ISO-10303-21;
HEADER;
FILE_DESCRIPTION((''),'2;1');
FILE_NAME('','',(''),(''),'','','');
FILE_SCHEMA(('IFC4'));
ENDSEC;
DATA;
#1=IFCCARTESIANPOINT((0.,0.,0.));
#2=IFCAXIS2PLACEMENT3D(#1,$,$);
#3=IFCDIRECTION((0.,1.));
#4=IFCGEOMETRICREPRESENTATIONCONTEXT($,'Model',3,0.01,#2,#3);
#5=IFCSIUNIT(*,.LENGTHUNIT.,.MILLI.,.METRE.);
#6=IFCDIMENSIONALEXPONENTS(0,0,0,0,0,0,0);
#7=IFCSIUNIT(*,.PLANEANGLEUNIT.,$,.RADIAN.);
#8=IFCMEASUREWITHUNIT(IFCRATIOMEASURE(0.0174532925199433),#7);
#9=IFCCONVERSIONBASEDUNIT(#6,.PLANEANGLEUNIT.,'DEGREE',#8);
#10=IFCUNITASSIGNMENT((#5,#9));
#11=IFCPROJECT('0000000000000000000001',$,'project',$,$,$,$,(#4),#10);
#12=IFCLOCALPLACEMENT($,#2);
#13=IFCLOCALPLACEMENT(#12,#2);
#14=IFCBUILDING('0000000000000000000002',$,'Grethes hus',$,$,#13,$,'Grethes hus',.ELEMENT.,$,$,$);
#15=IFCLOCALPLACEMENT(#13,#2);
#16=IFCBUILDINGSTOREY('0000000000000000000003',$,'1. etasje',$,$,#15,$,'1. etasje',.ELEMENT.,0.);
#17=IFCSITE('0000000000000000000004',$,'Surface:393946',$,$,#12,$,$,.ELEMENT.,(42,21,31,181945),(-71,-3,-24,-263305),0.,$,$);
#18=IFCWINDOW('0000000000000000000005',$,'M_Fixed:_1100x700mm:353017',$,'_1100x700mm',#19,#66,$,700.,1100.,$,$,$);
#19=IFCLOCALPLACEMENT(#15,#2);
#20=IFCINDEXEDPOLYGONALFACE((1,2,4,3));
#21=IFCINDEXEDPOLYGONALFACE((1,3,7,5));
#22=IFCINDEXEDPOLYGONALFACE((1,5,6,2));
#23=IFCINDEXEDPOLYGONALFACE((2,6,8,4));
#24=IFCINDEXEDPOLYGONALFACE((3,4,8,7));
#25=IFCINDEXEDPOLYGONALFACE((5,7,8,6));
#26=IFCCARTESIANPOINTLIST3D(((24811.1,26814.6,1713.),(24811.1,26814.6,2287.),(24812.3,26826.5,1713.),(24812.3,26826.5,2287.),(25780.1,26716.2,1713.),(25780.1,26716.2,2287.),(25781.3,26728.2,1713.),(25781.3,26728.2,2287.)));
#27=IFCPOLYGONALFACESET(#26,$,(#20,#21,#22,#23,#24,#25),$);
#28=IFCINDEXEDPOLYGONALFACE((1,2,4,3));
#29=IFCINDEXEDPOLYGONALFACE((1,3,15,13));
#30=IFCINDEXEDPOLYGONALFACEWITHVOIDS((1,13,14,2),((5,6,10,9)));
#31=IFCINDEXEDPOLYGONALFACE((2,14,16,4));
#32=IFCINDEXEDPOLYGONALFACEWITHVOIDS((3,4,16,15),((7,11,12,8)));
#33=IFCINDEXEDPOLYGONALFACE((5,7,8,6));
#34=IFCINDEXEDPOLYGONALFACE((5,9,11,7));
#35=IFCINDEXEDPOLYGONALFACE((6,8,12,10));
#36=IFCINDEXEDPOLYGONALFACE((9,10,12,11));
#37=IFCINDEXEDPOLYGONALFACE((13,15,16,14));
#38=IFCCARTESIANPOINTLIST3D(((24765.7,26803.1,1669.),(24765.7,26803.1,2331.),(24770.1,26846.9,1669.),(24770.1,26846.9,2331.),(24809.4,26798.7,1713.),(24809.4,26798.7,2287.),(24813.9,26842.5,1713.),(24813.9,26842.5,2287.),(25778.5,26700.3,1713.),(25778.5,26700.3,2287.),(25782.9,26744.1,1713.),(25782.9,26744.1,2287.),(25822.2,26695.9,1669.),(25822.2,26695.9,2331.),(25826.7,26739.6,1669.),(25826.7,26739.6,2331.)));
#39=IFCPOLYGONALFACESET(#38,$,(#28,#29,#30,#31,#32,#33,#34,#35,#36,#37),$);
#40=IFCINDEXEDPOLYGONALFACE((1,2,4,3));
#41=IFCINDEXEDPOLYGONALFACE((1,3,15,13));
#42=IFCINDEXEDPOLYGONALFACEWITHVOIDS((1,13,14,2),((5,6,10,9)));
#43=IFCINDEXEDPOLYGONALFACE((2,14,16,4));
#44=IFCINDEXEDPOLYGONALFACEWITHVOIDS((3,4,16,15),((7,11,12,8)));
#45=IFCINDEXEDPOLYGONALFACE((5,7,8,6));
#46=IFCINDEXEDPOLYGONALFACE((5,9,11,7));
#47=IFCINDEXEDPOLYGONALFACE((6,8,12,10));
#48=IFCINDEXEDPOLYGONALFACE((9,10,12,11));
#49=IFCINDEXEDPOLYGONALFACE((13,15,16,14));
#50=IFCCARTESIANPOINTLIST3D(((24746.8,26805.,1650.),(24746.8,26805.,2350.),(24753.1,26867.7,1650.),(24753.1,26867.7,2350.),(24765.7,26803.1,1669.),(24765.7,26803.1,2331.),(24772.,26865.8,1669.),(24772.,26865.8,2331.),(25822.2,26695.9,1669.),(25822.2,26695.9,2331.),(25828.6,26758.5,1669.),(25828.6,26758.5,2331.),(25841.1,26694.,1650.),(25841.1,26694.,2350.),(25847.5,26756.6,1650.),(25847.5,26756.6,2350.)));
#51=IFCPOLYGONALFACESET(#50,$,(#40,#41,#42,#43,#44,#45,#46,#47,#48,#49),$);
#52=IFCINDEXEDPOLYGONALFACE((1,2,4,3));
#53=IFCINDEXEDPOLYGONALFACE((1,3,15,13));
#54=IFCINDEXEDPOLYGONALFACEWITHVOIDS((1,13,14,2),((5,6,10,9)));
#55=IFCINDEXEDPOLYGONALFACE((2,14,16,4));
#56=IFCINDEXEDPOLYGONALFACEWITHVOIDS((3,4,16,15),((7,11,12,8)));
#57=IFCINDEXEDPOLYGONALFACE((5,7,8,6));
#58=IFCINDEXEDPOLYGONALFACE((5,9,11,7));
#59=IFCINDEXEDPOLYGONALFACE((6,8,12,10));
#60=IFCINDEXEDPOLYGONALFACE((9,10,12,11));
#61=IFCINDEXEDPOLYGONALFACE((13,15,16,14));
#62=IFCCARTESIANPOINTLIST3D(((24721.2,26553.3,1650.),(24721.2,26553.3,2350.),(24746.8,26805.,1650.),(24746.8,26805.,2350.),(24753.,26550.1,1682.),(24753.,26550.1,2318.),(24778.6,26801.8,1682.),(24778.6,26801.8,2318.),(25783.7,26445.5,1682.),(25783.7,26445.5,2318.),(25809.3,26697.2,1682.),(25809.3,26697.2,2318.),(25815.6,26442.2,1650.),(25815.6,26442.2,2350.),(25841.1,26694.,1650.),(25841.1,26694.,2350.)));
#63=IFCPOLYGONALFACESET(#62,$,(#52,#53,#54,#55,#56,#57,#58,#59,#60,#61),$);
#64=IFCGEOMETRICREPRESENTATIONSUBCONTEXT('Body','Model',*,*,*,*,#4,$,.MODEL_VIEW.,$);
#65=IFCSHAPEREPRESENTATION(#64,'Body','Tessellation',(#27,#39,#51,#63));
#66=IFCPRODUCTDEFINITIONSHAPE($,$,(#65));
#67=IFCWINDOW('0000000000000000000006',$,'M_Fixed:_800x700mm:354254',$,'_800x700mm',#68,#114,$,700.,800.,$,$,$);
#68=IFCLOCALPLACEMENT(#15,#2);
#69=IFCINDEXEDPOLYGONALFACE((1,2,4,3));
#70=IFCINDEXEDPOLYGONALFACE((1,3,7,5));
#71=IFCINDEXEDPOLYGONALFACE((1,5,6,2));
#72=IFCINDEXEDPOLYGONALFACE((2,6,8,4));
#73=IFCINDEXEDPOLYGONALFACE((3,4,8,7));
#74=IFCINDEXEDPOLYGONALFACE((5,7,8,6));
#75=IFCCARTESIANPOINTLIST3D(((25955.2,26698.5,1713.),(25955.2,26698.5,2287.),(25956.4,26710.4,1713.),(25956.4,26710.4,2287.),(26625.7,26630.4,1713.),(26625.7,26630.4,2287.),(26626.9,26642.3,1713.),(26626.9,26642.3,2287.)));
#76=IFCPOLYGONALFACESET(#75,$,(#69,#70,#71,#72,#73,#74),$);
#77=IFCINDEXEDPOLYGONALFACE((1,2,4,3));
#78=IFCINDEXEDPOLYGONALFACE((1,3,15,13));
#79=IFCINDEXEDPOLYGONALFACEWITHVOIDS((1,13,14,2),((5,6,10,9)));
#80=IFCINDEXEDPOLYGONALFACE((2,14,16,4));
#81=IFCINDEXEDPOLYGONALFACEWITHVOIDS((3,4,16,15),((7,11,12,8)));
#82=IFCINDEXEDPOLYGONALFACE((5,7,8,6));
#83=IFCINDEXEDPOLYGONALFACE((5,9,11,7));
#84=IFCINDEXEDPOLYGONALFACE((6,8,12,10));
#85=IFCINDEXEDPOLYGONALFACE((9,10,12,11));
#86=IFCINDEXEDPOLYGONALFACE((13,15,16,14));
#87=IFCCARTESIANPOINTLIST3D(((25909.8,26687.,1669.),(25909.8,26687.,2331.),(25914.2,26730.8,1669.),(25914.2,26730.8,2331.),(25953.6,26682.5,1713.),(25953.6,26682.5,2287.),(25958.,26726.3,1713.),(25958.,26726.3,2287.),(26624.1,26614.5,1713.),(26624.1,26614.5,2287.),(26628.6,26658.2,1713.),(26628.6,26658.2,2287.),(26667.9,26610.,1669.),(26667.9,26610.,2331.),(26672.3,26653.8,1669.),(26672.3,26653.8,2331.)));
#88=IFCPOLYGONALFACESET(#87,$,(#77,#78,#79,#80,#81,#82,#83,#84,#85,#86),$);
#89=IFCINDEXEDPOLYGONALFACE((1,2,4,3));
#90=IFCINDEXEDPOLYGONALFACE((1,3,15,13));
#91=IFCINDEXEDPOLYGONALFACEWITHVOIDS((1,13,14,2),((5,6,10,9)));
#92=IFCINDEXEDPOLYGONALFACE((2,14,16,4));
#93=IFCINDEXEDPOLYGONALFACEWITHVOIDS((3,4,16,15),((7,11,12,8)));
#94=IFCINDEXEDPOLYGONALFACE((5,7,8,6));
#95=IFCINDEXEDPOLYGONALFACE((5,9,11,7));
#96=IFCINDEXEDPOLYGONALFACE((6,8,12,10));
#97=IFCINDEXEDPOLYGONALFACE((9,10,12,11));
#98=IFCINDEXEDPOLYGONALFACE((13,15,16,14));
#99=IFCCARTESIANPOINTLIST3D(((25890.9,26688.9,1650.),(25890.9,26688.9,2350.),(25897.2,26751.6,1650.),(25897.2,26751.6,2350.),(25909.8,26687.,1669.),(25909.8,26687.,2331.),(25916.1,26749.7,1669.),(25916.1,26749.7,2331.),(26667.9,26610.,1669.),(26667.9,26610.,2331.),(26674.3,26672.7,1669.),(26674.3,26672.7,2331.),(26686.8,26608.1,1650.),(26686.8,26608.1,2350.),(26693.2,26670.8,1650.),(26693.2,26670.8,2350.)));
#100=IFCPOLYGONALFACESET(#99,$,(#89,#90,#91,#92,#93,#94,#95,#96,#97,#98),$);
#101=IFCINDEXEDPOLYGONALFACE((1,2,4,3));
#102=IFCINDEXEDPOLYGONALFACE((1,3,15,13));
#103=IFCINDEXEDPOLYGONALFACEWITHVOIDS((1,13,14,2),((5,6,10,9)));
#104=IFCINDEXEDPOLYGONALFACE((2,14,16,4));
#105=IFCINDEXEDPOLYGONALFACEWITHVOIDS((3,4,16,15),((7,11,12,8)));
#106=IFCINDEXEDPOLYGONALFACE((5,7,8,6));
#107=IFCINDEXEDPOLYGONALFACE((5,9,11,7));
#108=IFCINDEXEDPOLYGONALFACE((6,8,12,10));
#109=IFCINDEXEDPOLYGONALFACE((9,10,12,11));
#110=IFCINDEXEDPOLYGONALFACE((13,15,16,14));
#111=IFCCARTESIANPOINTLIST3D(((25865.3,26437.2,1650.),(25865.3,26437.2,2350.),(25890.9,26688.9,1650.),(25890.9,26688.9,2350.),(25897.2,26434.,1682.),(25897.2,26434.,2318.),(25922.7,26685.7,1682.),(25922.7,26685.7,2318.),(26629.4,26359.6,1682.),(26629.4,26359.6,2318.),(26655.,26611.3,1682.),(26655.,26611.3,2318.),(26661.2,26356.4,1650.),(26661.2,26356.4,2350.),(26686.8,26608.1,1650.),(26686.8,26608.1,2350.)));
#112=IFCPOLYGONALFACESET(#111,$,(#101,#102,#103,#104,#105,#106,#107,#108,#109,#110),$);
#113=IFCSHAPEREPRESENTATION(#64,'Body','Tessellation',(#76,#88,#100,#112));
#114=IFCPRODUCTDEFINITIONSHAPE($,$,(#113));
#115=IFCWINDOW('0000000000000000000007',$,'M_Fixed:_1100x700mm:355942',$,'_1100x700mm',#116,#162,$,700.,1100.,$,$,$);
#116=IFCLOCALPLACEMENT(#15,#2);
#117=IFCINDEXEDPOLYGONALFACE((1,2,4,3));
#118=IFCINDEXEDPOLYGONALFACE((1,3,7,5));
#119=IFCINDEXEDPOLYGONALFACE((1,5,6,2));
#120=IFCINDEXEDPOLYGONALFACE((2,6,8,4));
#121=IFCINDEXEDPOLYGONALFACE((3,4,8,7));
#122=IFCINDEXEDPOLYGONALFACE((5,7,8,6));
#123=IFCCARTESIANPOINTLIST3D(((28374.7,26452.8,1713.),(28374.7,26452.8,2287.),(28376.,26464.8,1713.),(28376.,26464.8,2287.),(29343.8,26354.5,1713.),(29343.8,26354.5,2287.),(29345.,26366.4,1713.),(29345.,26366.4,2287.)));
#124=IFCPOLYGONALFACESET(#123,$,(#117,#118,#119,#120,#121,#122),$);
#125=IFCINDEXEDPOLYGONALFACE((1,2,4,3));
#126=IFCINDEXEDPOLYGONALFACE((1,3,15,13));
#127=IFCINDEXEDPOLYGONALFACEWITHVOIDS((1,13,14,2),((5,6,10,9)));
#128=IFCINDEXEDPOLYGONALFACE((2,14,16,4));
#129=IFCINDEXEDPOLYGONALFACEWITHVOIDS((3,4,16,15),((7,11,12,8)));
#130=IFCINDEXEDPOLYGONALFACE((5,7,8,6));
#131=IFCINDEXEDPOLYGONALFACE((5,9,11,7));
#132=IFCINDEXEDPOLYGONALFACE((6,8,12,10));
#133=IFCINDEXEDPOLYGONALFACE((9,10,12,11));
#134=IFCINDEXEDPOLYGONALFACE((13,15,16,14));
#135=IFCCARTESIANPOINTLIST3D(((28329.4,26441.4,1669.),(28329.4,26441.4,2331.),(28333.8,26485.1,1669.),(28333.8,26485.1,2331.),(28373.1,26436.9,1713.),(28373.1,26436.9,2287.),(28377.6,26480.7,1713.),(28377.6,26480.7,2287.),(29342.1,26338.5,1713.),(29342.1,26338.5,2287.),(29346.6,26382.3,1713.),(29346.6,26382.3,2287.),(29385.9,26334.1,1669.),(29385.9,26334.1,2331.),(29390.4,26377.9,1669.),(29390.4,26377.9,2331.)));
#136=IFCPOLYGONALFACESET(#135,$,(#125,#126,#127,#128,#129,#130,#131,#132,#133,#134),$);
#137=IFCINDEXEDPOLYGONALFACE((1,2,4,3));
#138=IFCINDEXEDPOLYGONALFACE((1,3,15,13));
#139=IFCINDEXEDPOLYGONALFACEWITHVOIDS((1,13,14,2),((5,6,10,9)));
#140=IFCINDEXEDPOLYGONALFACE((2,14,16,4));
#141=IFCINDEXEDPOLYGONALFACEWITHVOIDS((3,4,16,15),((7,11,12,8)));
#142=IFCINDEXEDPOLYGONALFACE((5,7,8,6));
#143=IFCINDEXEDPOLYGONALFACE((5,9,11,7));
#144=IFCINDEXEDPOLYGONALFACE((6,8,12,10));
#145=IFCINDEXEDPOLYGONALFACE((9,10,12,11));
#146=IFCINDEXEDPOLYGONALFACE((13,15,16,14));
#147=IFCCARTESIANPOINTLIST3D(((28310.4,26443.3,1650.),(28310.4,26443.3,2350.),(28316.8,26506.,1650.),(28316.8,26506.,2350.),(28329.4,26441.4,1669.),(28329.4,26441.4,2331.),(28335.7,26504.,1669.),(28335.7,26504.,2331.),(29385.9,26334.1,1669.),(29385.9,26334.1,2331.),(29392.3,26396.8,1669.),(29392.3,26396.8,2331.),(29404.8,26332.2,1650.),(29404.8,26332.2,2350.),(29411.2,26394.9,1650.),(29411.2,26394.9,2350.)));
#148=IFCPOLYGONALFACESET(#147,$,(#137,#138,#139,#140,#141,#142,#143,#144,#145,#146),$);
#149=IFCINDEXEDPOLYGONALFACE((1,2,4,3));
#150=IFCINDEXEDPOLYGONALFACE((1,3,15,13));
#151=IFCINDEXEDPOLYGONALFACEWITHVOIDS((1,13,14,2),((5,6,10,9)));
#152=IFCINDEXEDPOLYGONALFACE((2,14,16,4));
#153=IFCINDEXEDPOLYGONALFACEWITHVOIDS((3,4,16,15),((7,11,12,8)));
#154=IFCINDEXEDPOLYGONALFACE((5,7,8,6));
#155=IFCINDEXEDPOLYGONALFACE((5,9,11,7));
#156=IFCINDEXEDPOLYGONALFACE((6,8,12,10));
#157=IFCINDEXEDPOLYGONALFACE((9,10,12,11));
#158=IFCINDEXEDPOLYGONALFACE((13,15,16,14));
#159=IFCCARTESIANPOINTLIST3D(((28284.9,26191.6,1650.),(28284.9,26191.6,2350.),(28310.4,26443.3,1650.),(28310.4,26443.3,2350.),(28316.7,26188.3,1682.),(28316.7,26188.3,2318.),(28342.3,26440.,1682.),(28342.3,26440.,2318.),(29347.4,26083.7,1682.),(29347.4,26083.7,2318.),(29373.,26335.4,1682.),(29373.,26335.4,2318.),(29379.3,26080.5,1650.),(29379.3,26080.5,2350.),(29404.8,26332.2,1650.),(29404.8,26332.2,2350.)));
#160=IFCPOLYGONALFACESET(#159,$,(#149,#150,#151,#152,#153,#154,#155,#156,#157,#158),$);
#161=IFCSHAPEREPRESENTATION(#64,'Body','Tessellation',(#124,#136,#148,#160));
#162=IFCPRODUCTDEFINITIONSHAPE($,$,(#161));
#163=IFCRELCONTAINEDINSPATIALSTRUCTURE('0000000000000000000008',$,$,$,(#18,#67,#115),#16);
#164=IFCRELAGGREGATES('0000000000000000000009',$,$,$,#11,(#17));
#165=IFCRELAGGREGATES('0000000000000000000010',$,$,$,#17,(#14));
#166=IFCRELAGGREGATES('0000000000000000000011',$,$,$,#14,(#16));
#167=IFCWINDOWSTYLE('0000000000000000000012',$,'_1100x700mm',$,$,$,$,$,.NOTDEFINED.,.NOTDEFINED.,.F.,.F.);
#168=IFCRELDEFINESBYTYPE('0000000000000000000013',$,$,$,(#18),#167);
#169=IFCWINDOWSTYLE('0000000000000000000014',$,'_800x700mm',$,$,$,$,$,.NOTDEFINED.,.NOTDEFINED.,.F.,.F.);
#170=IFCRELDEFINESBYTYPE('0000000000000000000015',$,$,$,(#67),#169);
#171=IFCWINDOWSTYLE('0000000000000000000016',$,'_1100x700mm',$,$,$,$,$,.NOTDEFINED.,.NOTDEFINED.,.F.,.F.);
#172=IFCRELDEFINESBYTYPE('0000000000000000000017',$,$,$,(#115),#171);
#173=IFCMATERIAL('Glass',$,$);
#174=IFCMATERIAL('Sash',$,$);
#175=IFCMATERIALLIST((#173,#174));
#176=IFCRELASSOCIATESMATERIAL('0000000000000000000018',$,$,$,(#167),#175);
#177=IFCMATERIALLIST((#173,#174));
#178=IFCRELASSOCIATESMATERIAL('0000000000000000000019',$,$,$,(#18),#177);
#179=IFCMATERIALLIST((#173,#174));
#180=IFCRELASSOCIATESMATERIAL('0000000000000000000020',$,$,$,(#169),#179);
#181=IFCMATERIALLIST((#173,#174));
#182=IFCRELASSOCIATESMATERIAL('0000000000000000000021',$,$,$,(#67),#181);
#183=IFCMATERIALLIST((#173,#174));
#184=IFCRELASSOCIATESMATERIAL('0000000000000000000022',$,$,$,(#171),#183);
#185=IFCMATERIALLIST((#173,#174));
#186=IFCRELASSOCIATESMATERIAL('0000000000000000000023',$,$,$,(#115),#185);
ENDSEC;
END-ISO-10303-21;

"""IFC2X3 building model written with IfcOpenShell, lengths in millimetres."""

from ifc_helpers import new_model, entity, si_unit, converted_unit, direction, frame, frame_2d, origin, place, context, subcontext, project, spatial, polyline, rectangle, outline, extrude, source, transform, mapped, material, material_list, type_object, type_shapes, element, save


model = new_model("IFC2X3")

# Units and contexts
model_context = context("Model", 3, precision=0.01, world=origin(), true_north=direction((0.0, 1.0)))
body_context = subcontext(model_context, "Body", "Model", "MODEL_VIEW")
ifc_project = project(units=[si_unit("LENGTHUNIT", "METRE", prefix="MILLI"), converted_unit("PLANEANGLEUNIT", "DEGREE", entity("IfcRatioMeasure", 0.0174532925199433), si_unit("PLANEANGLEUNIT", "RADIAN"), dimensions=[0, 0, 0, 0, 0, 0, 0])], contexts=[model_context])

# Site, building, storey
site_placement = place(None, origin())
site = spatial("IfcSite", under=ifc_project, at=site_placement, Name="Surface:393946", CompositionType="ELEMENT", RefLatitude=(42, 21, 31, 181945), RefLongitude=(-71, -3, -24, -263305), RefElevation=0.0)
building_placement = place(site_placement, origin())
building = spatial("IfcBuilding", under=site, at=building_placement, Name="Grethes hus", LongName="Grethes hus", CompositionType="ELEMENT")
storey_placement = place(building_placement, origin())
storey = spatial("IfcBuildingStorey", under=building, at=storey_placement, Name="1. etasje", LongName="1. etasje", CompositionType="ELEMENT", Elevation=0.0)

# Windows
ifc_material_1 = material(Name="Glass")
ifc_material_2 = material(Name="Sash")
ifc_material_list_1 = material_list([ifc_material_1, ifc_material_2])
ifc_material_list_2 = material_list([ifc_material_1, ifc_material_2])
window_style_1 = type_object("IfcWindowStyle", Name="_1100x700mm", ConstructionType="NOTDEFINED", OperationType="NOTDEFINED", ParameterTakesPrecedence=False, Sizeable=False, material=ifc_material_list_2)
shared_shape_1 = source(origin(), body_context, "Body", "SweptSolid", [
    extrude(rectangle(XDim=12.0, YDim=974.0, at=frame_2d((0.0, 0.0), x_axis=(1.0, 0.0))), frame((550.0, 275.0, 63.0), z_axis=(0.0, 0.0, 1.0), x_axis=(0.0, -1.0, 0.0)), (0.0, 0.0, 1.0), 574.0),
    extrude(outline(polyline([(-531.0, -331.0), (531.0, -331.0), (531.0, 331.0), (-531.0, 331.0), (-531.0, -331.0)]), holes=[polyline([(-487.0, -287.0), (-487.0, 287.0), (487.0, 287.0), (487.0, -287.0), (-487.0, -287.0)])]), frame((550.0, 253.0, 350.0), z_axis=(0.0, 1.0, 0.0), x_axis=(1.0, 0.0, 0.0)), (0.0, 0.0, 1.0), 44.0),
    extrude(outline(polyline([(-550.0, -350.0), (550.0, -350.0), (550.0, 350.0), (-550.0, 350.0), (-550.0, -350.0)]), holes=[polyline([(-531.0, -331.0), (-531.0, 331.0), (531.0, 331.0), (531.0, -331.0), (-531.0, -331.0)])]), frame((550.0, 253.0, 350.0), z_axis=(0.0, 1.0, 0.0), x_axis=(1.0, 0.0, 0.0)), (0.0, 0.0, 1.0), 63.0),
    extrude(outline(polyline([(-550.0, -350.0), (550.0, -350.0), (550.0, 350.0), (-550.0, 350.0), (-550.0, -350.0)]), holes=[polyline([(-518.0, -318.0), (-518.0, 318.0), (518.0, 318.0), (518.0, -318.0), (-518.0, -318.0)])]), frame((550.0, 0.0, 350.0), z_axis=(0.0, 1.0, 0.0), x_axis=(1.0, 0.0, 0.0)), (0.0, 0.0, 1.0), 253.0),
])
type_shapes(window_style_1, [shared_shape_1])
placement_1 = place(storey_placement, frame((17757.0, 27419.1, 400.0), z_axis=(0.0, 0.0, 1.0), x_axis=(0.994887, -0.100996, 0.0)))
placement_2 = place(placement_1, frame((7016.0, -158.0, 1250.0)))
window_1_placement = place(placement_2, origin())
element("IfcWindow", 1, at=window_1_placement, inside=storey, type_object=window_style_1, material=ifc_material_list_1, Name="M_Fixed:_1100x700mm:353017", ObjectType="_1100x700mm", OverallHeight=700.0, OverallWidth=1100.0, context=body_context, shape_type="MappedRepresentation", body=[
    mapped(shared_shape_1, transform((0.0, 0.0, 0.0), scale=1.0)),
])
ifc_material_list_3 = material_list([ifc_material_1, ifc_material_2])
ifc_material_list_4 = material_list([ifc_material_1, ifc_material_2])
window_style_2 = type_object("IfcWindowStyle", Name="_800x700mm", ConstructionType="NOTDEFINED", OperationType="NOTDEFINED", ParameterTakesPrecedence=False, Sizeable=False, material=ifc_material_list_4)
shared_shape_2 = source(origin(), body_context, "Body", "SweptSolid", [
    extrude(rectangle(XDim=12.0, YDim=674.0, at=frame_2d((0.0, 0.0), x_axis=(1.0, 0.0))), frame((400.0, 275.0, 63.0), z_axis=(0.0, 0.0, 1.0), x_axis=(0.0, -1.0, 0.0)), (0.0, 0.0, 1.0), 574.0),
    extrude(outline(polyline([(-381.0, -331.0), (381.0, -331.0), (381.0, 331.0), (-381.0, 331.0), (-381.0, -331.0)]), holes=[polyline([(-337.0, -287.0), (-337.0, 287.0), (337.0, 287.0), (337.0, -287.0), (-337.0, -287.0)])]), frame((400.0, 253.0, 350.0), z_axis=(0.0, 1.0, 0.0), x_axis=(1.0, 0.0, 0.0)), (0.0, 0.0, 1.0), 44.0),
    extrude(outline(polyline([(-400.0, -350.0), (400.0, -350.0), (400.0, 350.0), (-400.0, 350.0), (-400.0, -350.0)]), holes=[polyline([(-381.0, -331.0), (-381.0, 331.0), (381.0, 331.0), (381.0, -331.0), (-381.0, -331.0)])]), frame((400.0, 253.0, 350.0), z_axis=(0.0, 1.0, 0.0), x_axis=(1.0, 0.0, 0.0)), (0.0, 0.0, 1.0), 63.0),
    extrude(outline(polyline([(-400.0, -350.0), (400.0, -350.0), (400.0, 350.0), (-400.0, 350.0), (-400.0, -350.0)]), holes=[polyline([(-368.0, -318.0), (-368.0, 318.0), (368.0, 318.0), (368.0, -318.0), (-368.0, -318.0)])]), frame((400.0, 0.0, 350.0), z_axis=(0.0, 1.0, 0.0), x_axis=(1.0, 0.0, 0.0)), (0.0, 0.0, 1.0), 253.0),
])
type_shapes(window_style_2, [shared_shape_2])
placement_3 = place(placement_1, frame((8166.0, -158.0, 1250.0)))
window_2_placement = place(placement_3, origin())
element("IfcWindow", 2, at=window_2_placement, inside=storey, type_object=window_style_2, material=ifc_material_list_3, Name="M_Fixed:_800x700mm:354254", ObjectType="_800x700mm", OverallHeight=700.0, OverallWidth=800.0, context=body_context, shape_type="MappedRepresentation", body=[
    mapped(shared_shape_2, transform((0.0, 0.0, 0.0), scale=1.0)),
])

# Window
ifc_material_list_5 = material_list([ifc_material_1, ifc_material_2])
ifc_material_list_6 = material_list([ifc_material_1, ifc_material_2])
window_style_3 = type_object("IfcWindowStyle", Name="_1100x700mm", ConstructionType="NOTDEFINED", OperationType="NOTDEFINED", ParameterTakesPrecedence=False, Sizeable=False, material=ifc_material_list_6)
shared_shape_3 = source(origin(), body_context, "Body", "SweptSolid", [
    extrude(rectangle(XDim=974.0, YDim=12.0, at=frame_2d((0.0, 0.0), x_axis=(1.0, 0.0))), frame((550.0, 301.0, 63.0), z_axis=(0.0, 0.0, 1.0), x_axis=(-1.0, 0.0, 0.0)), (0.0, 0.0, 1.0), 574.0),
    extrude(outline(polyline([(-531.0, -331.0), (531.0, -331.0), (531.0, 331.0), (-531.0, 331.0), (-531.0, -331.0)]), holes=[polyline([(-487.0, -287.0), (-487.0, 287.0), (487.0, 287.0), (487.0, -287.0), (-487.0, -287.0)])]), frame((550.0, 323.0, 350.0), z_axis=(0.0, -1.0, 0.0), x_axis=(-1.0, 0.0, 0.0)), (0.0, 0.0, 1.0), 44.0),
    extrude(outline(polyline([(-550.0, -350.0), (550.0, -350.0), (550.0, 350.0), (-550.0, 350.0), (-550.0, -350.0)]), holes=[polyline([(-531.0, -331.0), (-531.0, 331.0), (531.0, 331.0), (531.0, -331.0), (-531.0, -331.0)])]), frame((550.0, 342.0, 350.0), z_axis=(0.0, -1.0, 0.0), x_axis=(-1.0, 0.0, 0.0)), (0.0, 0.0, 1.0), 63.0),
    extrude(outline(polyline([(-550.0, -350.0), (550.0, -350.0), (550.0, 350.0), (-550.0, 350.0), (-550.0, -350.0)]), holes=[polyline([(-518.0, -318.0), (-518.0, 318.0), (518.0, 318.0), (518.0, -318.0), (-518.0, -318.0)])]), frame((550.0, 279.0, 350.0), z_axis=(0.0, -1.0, 0.0), x_axis=(-1.0, 0.0, 0.0)), (0.0, 0.0, 1.0), 253.0),
])
type_shapes(window_style_3, [shared_shape_3])
placement_4 = place(placement_1, frame((10598.0, -158.0, 1250.0)))
window_3_placement = place(placement_4, frame((0.0, -26.0, 0.0)))
element("IfcWindow", 3, at=window_3_placement, inside=storey, type_object=window_style_3, material=ifc_material_list_5, Name="M_Fixed:_1100x700mm:355942", ObjectType="_1100x700mm", OverallHeight=700.0, OverallWidth=1100.0, context=body_context, shape_type="MappedRepresentation", body=[
    mapped(shared_shape_3, transform((0.0, 0.0, 0.0), scale=1.0)),
])

save(model, "model.ifc")
